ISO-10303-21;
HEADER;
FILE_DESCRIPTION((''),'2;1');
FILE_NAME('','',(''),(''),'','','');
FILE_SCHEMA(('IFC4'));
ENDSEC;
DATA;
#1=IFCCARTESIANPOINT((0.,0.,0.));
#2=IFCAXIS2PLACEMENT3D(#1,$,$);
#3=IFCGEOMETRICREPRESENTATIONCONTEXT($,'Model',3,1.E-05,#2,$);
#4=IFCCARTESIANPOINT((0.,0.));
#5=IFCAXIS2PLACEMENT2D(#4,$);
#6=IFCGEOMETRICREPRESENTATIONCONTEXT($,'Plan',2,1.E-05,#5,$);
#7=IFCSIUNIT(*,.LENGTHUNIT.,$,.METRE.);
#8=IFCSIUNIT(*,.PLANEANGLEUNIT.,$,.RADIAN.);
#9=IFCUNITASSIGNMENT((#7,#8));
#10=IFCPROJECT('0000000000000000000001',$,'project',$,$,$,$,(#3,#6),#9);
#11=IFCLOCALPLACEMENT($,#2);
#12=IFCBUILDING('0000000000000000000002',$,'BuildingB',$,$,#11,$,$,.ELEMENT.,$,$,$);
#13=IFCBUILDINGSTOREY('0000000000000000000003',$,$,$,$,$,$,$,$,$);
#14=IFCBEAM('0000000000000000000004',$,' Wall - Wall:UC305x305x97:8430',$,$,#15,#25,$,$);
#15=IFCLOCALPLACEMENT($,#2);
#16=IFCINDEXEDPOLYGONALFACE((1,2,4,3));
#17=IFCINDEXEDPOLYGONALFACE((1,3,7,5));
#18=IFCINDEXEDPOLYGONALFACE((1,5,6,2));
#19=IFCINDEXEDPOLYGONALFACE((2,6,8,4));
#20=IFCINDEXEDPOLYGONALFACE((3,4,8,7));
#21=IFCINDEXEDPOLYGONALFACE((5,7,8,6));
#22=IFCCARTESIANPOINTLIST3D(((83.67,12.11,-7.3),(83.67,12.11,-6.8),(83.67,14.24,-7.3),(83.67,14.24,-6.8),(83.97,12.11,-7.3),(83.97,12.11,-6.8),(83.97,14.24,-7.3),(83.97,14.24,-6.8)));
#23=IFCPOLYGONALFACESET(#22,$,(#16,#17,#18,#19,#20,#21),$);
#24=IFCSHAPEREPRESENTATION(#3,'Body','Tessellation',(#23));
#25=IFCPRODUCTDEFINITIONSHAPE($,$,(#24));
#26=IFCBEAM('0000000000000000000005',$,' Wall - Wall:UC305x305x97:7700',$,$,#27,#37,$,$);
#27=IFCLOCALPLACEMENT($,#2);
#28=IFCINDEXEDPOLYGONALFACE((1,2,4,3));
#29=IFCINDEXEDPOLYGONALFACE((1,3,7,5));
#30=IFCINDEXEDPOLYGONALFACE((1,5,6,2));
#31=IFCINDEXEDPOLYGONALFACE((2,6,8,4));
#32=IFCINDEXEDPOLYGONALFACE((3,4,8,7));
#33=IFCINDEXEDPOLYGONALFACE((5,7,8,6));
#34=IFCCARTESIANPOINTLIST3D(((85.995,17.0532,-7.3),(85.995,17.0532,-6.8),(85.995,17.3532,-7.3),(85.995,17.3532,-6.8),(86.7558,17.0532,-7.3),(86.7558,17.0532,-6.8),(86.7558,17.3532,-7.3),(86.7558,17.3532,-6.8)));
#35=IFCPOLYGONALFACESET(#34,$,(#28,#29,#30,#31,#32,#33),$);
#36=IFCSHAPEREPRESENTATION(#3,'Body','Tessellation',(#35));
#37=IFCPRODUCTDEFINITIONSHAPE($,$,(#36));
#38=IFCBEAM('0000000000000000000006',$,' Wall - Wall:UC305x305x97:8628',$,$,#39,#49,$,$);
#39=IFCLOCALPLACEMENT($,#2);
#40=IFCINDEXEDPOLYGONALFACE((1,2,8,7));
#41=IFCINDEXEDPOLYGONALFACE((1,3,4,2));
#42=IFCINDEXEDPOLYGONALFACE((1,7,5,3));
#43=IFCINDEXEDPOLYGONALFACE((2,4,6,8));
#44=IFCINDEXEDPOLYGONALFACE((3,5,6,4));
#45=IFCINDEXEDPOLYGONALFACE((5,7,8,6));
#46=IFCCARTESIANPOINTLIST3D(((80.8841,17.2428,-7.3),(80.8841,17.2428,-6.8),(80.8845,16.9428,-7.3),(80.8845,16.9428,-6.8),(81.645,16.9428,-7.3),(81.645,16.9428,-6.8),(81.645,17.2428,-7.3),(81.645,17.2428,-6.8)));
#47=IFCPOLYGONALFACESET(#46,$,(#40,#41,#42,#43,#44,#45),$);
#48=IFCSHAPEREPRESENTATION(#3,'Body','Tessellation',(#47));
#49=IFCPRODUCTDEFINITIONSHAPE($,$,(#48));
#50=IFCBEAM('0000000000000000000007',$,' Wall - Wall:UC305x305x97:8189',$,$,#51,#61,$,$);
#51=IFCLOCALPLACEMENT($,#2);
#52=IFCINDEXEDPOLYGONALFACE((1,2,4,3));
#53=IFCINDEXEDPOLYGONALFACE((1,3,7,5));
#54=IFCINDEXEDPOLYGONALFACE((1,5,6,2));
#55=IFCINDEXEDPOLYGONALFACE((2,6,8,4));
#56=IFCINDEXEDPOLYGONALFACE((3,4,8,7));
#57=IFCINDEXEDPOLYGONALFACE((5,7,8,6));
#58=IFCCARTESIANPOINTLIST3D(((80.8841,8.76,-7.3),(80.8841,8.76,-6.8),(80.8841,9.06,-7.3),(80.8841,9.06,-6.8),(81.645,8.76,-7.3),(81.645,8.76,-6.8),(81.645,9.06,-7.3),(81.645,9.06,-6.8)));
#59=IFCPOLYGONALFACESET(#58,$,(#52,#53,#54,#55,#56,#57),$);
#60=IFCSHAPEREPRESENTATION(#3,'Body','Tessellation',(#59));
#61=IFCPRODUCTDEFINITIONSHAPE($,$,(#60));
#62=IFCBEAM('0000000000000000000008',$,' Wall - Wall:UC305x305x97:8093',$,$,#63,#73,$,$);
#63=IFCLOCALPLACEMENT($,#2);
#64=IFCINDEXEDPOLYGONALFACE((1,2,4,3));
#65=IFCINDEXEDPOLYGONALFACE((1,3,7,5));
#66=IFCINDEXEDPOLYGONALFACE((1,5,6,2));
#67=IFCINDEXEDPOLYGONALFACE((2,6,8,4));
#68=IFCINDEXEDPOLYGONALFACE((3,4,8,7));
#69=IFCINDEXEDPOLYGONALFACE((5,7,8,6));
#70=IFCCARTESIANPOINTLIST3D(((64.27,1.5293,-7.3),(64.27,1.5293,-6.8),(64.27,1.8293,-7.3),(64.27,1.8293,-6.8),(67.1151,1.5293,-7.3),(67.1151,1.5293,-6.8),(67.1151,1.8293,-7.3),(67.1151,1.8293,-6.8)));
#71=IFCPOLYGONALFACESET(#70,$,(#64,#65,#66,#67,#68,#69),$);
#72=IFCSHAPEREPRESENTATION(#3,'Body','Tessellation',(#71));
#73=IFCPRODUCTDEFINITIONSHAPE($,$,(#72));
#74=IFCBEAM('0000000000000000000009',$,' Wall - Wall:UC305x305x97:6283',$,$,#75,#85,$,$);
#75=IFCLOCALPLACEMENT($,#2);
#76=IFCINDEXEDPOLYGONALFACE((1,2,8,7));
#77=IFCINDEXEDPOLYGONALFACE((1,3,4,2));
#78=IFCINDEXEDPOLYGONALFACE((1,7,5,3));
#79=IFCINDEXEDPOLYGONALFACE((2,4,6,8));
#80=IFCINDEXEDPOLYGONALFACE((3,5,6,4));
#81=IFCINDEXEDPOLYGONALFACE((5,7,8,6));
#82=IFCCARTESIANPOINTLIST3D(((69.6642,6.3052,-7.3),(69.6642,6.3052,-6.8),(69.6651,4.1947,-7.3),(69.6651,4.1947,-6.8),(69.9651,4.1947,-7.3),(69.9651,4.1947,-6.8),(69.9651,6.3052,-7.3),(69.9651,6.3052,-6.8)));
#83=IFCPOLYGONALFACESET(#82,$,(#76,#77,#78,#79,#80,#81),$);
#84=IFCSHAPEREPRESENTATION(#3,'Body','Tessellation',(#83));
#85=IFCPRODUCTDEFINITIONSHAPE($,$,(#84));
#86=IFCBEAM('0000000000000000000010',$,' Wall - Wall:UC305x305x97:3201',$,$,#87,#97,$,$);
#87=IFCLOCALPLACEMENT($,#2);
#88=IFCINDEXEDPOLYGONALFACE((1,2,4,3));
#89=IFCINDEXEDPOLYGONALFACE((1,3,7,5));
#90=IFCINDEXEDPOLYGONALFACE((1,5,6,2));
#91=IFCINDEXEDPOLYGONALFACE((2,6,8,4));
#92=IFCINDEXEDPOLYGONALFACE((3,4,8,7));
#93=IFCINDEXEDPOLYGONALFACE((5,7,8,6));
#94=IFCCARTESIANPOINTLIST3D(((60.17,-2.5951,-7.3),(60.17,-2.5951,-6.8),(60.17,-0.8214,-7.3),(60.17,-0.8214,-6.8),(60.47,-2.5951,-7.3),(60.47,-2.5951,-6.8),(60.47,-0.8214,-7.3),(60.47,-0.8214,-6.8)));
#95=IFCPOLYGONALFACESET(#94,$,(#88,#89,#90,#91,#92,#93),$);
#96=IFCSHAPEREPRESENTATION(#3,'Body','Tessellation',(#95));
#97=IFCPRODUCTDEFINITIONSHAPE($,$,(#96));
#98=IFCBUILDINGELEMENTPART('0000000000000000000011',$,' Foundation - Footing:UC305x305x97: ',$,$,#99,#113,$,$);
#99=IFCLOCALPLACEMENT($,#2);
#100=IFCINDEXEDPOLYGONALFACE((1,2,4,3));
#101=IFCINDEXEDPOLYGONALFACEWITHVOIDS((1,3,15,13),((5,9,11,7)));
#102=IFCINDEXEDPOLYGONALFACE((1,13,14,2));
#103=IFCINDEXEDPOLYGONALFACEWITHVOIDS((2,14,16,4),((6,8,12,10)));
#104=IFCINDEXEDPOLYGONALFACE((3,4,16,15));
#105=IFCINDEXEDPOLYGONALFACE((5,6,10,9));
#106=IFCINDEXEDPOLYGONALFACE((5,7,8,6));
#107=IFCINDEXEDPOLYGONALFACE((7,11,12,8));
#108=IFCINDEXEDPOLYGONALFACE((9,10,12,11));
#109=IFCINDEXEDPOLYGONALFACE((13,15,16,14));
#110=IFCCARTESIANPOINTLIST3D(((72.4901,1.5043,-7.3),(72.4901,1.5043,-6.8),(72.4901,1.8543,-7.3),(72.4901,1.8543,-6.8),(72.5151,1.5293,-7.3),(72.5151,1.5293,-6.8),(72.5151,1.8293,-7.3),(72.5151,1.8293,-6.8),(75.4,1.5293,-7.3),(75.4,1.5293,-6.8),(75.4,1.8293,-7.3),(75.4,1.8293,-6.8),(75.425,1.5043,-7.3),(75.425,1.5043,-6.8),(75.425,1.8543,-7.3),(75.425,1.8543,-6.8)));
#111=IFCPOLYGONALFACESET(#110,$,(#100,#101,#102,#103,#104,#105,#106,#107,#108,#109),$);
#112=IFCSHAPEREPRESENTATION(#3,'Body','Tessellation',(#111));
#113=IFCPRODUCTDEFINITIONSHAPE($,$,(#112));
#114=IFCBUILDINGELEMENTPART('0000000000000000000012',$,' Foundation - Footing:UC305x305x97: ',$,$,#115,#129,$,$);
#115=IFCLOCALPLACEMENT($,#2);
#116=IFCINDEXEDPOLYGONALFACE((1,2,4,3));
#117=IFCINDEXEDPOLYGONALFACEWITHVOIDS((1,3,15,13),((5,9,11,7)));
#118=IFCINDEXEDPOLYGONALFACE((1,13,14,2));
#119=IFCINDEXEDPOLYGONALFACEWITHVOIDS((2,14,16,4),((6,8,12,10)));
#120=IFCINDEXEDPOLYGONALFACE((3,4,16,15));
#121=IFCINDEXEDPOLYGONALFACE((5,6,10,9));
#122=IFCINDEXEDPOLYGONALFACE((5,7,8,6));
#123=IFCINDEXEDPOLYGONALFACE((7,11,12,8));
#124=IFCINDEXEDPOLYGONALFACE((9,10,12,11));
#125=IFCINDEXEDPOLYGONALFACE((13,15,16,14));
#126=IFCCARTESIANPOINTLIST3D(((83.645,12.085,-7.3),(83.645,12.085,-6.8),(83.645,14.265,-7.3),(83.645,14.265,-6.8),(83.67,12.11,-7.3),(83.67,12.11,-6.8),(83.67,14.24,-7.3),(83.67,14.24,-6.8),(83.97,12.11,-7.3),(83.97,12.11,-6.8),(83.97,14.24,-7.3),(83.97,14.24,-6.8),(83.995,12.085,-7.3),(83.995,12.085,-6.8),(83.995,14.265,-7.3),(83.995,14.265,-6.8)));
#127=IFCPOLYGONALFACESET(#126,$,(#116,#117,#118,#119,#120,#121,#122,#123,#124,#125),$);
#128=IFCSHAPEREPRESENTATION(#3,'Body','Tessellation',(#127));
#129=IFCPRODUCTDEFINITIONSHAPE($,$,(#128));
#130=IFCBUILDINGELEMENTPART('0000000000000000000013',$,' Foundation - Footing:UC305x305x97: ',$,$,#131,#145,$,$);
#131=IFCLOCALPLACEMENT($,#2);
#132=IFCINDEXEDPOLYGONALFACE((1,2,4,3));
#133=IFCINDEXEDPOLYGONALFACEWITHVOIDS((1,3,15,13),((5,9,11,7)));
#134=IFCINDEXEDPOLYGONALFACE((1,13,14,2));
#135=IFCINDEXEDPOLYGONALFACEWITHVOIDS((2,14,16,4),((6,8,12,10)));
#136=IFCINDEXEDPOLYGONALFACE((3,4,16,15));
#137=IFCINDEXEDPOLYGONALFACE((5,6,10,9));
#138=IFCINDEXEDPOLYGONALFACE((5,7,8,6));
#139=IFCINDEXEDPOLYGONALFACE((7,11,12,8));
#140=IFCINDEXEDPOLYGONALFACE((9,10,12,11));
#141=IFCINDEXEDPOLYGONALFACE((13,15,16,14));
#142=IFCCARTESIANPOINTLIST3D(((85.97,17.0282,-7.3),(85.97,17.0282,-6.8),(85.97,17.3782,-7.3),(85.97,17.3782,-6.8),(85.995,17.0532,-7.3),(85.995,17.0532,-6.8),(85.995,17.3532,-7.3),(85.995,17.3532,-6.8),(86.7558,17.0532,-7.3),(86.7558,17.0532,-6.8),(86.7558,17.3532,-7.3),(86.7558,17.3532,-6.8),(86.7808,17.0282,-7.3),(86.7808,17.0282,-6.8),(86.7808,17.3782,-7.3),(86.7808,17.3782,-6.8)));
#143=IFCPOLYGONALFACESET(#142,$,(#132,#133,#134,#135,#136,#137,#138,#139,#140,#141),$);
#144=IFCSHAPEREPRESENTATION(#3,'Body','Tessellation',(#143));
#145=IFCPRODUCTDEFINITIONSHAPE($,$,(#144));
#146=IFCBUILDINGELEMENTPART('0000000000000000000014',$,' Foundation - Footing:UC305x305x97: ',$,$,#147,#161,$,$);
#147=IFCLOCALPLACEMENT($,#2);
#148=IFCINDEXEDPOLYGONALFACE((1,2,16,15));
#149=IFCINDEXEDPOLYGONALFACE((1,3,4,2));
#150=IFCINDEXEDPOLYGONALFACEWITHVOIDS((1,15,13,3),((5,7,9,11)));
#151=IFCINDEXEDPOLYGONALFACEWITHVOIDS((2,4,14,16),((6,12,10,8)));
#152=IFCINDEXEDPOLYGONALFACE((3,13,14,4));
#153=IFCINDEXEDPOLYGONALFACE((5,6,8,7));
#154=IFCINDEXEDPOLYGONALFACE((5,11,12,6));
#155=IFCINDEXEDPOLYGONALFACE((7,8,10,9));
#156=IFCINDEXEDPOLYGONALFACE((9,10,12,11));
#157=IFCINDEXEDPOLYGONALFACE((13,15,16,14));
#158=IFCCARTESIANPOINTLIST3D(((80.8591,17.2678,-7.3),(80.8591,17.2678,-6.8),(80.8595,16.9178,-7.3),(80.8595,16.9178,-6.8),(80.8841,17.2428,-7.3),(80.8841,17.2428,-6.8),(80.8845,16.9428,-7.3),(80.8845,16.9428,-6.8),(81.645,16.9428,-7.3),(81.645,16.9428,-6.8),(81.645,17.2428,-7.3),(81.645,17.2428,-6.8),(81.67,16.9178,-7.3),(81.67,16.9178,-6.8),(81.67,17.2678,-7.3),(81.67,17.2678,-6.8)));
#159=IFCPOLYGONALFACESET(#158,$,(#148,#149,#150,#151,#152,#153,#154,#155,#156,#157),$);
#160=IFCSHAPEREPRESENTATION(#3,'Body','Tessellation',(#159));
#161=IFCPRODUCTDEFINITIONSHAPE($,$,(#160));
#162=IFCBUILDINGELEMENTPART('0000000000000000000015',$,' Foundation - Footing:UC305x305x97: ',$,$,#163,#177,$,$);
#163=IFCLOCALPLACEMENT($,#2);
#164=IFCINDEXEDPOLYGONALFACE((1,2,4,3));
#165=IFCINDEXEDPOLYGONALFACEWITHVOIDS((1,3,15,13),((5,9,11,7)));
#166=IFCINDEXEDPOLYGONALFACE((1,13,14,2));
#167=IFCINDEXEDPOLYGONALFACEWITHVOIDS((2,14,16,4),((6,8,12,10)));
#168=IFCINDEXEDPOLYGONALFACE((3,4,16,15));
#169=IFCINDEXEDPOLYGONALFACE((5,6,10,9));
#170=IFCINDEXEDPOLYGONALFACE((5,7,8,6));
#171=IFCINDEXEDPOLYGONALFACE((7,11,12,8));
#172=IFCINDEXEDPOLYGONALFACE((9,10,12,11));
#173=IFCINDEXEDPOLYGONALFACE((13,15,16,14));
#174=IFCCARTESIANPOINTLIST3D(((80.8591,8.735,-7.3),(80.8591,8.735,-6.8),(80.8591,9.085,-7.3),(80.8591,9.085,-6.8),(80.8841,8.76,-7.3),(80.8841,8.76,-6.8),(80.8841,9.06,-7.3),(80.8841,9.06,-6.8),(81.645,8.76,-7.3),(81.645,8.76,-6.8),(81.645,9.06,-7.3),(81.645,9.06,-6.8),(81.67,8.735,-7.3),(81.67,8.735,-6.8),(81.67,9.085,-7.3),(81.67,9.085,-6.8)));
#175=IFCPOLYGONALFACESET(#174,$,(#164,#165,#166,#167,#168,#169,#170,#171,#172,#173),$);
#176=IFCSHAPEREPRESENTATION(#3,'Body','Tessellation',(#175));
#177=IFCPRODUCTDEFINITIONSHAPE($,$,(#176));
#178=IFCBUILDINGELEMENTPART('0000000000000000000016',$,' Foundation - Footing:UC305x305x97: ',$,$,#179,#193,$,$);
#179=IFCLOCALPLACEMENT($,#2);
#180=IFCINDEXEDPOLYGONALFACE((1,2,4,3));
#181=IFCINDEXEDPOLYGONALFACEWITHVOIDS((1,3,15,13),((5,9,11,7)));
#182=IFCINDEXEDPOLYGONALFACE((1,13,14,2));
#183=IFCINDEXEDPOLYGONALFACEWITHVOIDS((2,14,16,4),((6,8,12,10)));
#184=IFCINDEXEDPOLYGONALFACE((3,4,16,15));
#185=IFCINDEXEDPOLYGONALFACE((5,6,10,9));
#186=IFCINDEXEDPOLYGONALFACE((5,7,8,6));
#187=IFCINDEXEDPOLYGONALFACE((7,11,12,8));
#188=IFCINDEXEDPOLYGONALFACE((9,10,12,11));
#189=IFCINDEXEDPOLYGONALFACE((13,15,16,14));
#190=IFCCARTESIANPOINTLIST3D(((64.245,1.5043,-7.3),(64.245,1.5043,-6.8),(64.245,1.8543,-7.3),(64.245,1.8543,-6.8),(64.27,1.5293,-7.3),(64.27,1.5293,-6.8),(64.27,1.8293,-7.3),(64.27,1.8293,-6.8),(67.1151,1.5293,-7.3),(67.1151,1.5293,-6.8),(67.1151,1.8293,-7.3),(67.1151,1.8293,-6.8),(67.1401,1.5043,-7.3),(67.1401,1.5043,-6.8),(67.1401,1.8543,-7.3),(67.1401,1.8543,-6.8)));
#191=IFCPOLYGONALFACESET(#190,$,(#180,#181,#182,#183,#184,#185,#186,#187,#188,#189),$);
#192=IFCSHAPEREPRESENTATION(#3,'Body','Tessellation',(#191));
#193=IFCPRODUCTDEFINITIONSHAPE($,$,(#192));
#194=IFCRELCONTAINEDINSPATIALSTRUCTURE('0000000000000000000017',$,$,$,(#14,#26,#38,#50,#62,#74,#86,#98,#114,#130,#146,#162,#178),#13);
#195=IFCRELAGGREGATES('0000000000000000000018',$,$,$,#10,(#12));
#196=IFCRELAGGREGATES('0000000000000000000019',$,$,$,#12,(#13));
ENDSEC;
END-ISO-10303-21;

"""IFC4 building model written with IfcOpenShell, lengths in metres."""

from ifc_helpers import new_model, si_unit, origin, origin_2d, place, context, project, spatial, polyline, outline, extrude, element, save


model = new_model("IFC4")

# Units and contexts
model_context = context("Model", 3, precision=1e-05, world=origin())
plan_context = context("Plan", 2, precision=1e-05, world=origin_2d())
ifc_project = project(units=[si_unit("LENGTHUNIT", "METRE"), si_unit("PLANEANGLEUNIT", "RADIAN")], contexts=[model_context, plan_context])

# Building, storey
building_placement = place(None, origin())
building = spatial("IfcBuilding", under=ifc_project, at=building_placement, Name="BuildingB", CompositionType="ELEMENT")
storey = spatial("IfcBuildingStorey", under=building)

# Beams
element("IfcBeam", 1, inside=storey, Name=" Wall - Wall:UC305x305x97:8430", context=model_context, shape_type="SweptSolid", body=[
    extrude(outline(polyline([(83.97, 12.11, -7.3), (83.67, 12.11, -7.3), (83.67, 14.24, -7.3), (83.97, 14.24, -7.3), (83.97, 12.11, -7.3)])), None, (0.0, 0.0, 1.0), 0.5),
])
element("IfcBeam", 2, inside=storey, Name=" Wall - Wall:UC305x305x97:7700", context=model_context, shape_type="SweptSolid", body=[
    extrude(outline(polyline([(86.7558, 17.0532, -7.3), (86.7558, 17.3532, -7.3), (85.995, 17.3532, -7.3), (85.995, 17.0532, -7.3), (86.7558, 17.0532, -7.3)])), None, (0.0, 0.0, 1.0), 0.5),
])
element("IfcBeam", 3, inside=storey, Name=" Wall - Wall:UC305x305x97:8628", context=model_context, shape_type="SweptSolid", body=[
    extrude(outline(polyline([(81.645, 16.9428, -7.3), (80.8845, 16.9428, -7.3), (80.8841, 17.2428, -7.3), (81.645, 17.2428, -7.3), (81.645, 16.9428, -7.3)])), None, (0.0, 0.0, 1.0), 0.5),
])
element("IfcBeam", 4, inside=storey, Name=" Wall - Wall:UC305x305x97:8189", context=model_context, shape_type="SweptSolid", body=[
    extrude(outline(polyline([(81.645, 8.76, -7.3), (80.8841, 8.76, -7.3), (80.8841, 9.06, -7.3), (81.645, 9.06, -7.3), (81.645, 8.76, -7.3)])), None, (0.0, 0.0, 1.0), 0.5),
])
element("IfcBeam", 5, inside=storey, Name=" Wall - Wall:UC305x305x97:8093", context=model_context, shape_type="SweptSolid", body=[
    extrude(outline(polyline([(67.1151, 1.5293, -7.3), (67.1151, 1.8293, -7.3), (64.27, 1.8293, -7.3), (64.27, 1.5293, -7.3), (67.1151, 1.5293, -7.3)])), None, (0.0, 0.0, 1.0), 0.5),
])
element("IfcBeam", 6, inside=storey, Name=" Wall - Wall:UC305x305x97:6283", context=model_context, shape_type="SweptSolid", body=[
    extrude(outline(polyline([(69.9651, 4.1947, -7.3), (69.6651, 4.1947, -7.3), (69.6642, 6.3052, -7.3), (69.9651, 6.3052, -7.3), (69.9651, 4.1947, -7.3)])), None, (0.0, 0.0, 1.0), 0.5),
])
element("IfcBeam", 7, inside=storey, Name=" Wall - Wall:UC305x305x97:3201", context=model_context, shape_type="SweptSolid", body=[
    extrude(outline(polyline([(60.47, -2.5951, -7.3), (60.17, -2.5951, -7.3), (60.17, -0.8214, -7.3), (60.47, -0.8214, -7.3), (60.47, -2.5951, -7.3)])), None, (0.0, 0.0, 1.0), 0.5),
])

# Building element parts, openings
building_element_part_1 = element("IfcBuildingElementPart", 8, inside=storey, Name=" Foundation - Footing:UC305x305x97: ", context=model_context, shape_type="SweptSolid", body=[
    extrude(outline(polyline([(75.425, 1.5043, -7.3), (75.425, 1.8543, -7.3), (72.4901, 1.8543, -7.3), (72.4901, 1.5043, -7.3), (75.425, 1.5043, -7.3)])), None, (0.0, 0.0, 1.0), 0.5),
])
element("IfcOpeningElement", 9, inside=storey, cuts=building_element_part_1, context=model_context, shape_type="SweptSolid", body=[
    extrude(outline(polyline([(75.4, 1.5293, -7.3), (75.4, 1.8293, -7.3), (72.5151, 1.8293, -7.3), (72.5151, 1.5293, -7.3), (75.4, 1.5293, -7.3)])), None, (0.0, 0.0, 1.0), 0.5),
])
building_element_part_2 = element("IfcBuildingElementPart", 10, inside=storey, Name=" Foundation - Footing:UC305x305x97: ", context=model_context, shape_type="SweptSolid", body=[
    extrude(outline(polyline([(83.995, 12.085, -7.3), (83.645, 12.085, -7.3), (83.645, 14.265, -7.3), (83.995, 14.265, -7.3), (83.995, 12.085, -7.3)])), None, (0.0, 0.0, 1.0), 0.5),
])
element("IfcOpeningElement", 11, inside=storey, cuts=building_element_part_2, context=model_context, shape_type="SweptSolid", body=[
    extrude(outline(polyline([(83.97, 12.11, -7.3), (83.67, 12.11, -7.3), (83.67, 14.24, -7.3), (83.97, 14.24, -7.3), (83.97, 12.11, -7.3)])), None, (0.0, 0.0, 1.0), 0.5),
])
building_element_part_3 = element("IfcBuildingElementPart", 12, inside=storey, Name=" Foundation - Footing:UC305x305x97: ", context=model_context, shape_type="SweptSolid", body=[
    extrude(outline(polyline([(86.7808, 17.0282, -7.3), (86.7808, 17.3782, -7.3), (85.97, 17.3782, -7.3), (85.97, 17.0282, -7.3), (86.7808, 17.0282, -7.3)])), None, (0.0, 0.0, 1.0), 0.5),
])
element("IfcOpeningElement", 13, inside=storey, cuts=building_element_part_3, context=model_context, shape_type="SweptSolid", body=[
    extrude(outline(polyline([(86.7558, 17.0532, -7.3), (86.7558, 17.3532, -7.3), (85.995, 17.3532, -7.3), (85.995, 17.0532, -7.3), (86.7558, 17.0532, -7.3)])), None, (0.0, 0.0, 1.0), 0.5),
])
building_element_part_4 = element("IfcBuildingElementPart", 14, inside=storey, Name=" Foundation - Footing:UC305x305x97: ", context=model_context, shape_type="SweptSolid", body=[
    extrude(outline(polyline([(81.67, 16.9178, -7.3), (80.8595, 16.9178, -7.3), (80.8591, 17.2678, -7.3), (81.67, 17.2678, -7.3), (81.67, 16.9178, -7.3)])), None, (0.0, 0.0, 1.0), 0.5),
])
element("IfcOpeningElement", 15, inside=storey, cuts=building_element_part_4, context=model_context, shape_type="SweptSolid", body=[
    extrude(outline(polyline([(81.645, 16.9428, -7.3), (80.8845, 16.9428, -7.3), (80.8841, 17.2428, -7.3), (81.645, 17.2428, -7.3), (81.645, 16.9428, -7.3)])), None, (0.0, 0.0, 1.0), 0.5),
])
building_element_part_5 = element("IfcBuildingElementPart", 16, inside=storey, Name=" Foundation - Footing:UC305x305x97: ", context=model_context, shape_type="SweptSolid", body=[
    extrude(outline(polyline([(81.67, 8.735, -7.3), (80.8591, 8.735, -7.3), (80.8591, 9.085, -7.3), (81.67, 9.085, -7.3), (81.67, 8.735, -7.3)])), None, (0.0, 0.0, 1.0), 0.5),
])
element("IfcOpeningElement", 17, inside=storey, cuts=building_element_part_5, context=model_context, shape_type="SweptSolid", body=[
    extrude(outline(polyline([(81.645, 8.76, -7.3), (80.8841, 8.76, -7.3), (80.8841, 9.06, -7.3), (81.645, 9.06, -7.3), (81.645, 8.76, -7.3)])), None, (0.0, 0.0, 1.0), 0.5),
])
building_element_part_6 = element("IfcBuildingElementPart", 18, inside=storey, Name=" Foundation - Footing:UC305x305x97: ", context=model_context, shape_type="SweptSolid", body=[
    extrude(outline(polyline([(67.1401, 1.5043, -7.3), (67.1401, 1.8543, -7.3), (64.245, 1.8543, -7.3), (64.245, 1.5043, -7.3), (67.1401, 1.5043, -7.3)])), None, (0.0, 0.0, 1.0), 0.5),
])
element("IfcOpeningElement", 19, inside=storey, cuts=building_element_part_6, context=model_context, shape_type="SweptSolid", body=[
    extrude(outline(polyline([(67.1151, 1.5293, -7.3), (67.1151, 1.8293, -7.3), (64.27, 1.8293, -7.3), (64.27, 1.5293, -7.3), (67.1151, 1.5293, -7.3)])), None, (0.0, 0.0, 1.0), 0.5),
])

save(model, "model.ifc")
